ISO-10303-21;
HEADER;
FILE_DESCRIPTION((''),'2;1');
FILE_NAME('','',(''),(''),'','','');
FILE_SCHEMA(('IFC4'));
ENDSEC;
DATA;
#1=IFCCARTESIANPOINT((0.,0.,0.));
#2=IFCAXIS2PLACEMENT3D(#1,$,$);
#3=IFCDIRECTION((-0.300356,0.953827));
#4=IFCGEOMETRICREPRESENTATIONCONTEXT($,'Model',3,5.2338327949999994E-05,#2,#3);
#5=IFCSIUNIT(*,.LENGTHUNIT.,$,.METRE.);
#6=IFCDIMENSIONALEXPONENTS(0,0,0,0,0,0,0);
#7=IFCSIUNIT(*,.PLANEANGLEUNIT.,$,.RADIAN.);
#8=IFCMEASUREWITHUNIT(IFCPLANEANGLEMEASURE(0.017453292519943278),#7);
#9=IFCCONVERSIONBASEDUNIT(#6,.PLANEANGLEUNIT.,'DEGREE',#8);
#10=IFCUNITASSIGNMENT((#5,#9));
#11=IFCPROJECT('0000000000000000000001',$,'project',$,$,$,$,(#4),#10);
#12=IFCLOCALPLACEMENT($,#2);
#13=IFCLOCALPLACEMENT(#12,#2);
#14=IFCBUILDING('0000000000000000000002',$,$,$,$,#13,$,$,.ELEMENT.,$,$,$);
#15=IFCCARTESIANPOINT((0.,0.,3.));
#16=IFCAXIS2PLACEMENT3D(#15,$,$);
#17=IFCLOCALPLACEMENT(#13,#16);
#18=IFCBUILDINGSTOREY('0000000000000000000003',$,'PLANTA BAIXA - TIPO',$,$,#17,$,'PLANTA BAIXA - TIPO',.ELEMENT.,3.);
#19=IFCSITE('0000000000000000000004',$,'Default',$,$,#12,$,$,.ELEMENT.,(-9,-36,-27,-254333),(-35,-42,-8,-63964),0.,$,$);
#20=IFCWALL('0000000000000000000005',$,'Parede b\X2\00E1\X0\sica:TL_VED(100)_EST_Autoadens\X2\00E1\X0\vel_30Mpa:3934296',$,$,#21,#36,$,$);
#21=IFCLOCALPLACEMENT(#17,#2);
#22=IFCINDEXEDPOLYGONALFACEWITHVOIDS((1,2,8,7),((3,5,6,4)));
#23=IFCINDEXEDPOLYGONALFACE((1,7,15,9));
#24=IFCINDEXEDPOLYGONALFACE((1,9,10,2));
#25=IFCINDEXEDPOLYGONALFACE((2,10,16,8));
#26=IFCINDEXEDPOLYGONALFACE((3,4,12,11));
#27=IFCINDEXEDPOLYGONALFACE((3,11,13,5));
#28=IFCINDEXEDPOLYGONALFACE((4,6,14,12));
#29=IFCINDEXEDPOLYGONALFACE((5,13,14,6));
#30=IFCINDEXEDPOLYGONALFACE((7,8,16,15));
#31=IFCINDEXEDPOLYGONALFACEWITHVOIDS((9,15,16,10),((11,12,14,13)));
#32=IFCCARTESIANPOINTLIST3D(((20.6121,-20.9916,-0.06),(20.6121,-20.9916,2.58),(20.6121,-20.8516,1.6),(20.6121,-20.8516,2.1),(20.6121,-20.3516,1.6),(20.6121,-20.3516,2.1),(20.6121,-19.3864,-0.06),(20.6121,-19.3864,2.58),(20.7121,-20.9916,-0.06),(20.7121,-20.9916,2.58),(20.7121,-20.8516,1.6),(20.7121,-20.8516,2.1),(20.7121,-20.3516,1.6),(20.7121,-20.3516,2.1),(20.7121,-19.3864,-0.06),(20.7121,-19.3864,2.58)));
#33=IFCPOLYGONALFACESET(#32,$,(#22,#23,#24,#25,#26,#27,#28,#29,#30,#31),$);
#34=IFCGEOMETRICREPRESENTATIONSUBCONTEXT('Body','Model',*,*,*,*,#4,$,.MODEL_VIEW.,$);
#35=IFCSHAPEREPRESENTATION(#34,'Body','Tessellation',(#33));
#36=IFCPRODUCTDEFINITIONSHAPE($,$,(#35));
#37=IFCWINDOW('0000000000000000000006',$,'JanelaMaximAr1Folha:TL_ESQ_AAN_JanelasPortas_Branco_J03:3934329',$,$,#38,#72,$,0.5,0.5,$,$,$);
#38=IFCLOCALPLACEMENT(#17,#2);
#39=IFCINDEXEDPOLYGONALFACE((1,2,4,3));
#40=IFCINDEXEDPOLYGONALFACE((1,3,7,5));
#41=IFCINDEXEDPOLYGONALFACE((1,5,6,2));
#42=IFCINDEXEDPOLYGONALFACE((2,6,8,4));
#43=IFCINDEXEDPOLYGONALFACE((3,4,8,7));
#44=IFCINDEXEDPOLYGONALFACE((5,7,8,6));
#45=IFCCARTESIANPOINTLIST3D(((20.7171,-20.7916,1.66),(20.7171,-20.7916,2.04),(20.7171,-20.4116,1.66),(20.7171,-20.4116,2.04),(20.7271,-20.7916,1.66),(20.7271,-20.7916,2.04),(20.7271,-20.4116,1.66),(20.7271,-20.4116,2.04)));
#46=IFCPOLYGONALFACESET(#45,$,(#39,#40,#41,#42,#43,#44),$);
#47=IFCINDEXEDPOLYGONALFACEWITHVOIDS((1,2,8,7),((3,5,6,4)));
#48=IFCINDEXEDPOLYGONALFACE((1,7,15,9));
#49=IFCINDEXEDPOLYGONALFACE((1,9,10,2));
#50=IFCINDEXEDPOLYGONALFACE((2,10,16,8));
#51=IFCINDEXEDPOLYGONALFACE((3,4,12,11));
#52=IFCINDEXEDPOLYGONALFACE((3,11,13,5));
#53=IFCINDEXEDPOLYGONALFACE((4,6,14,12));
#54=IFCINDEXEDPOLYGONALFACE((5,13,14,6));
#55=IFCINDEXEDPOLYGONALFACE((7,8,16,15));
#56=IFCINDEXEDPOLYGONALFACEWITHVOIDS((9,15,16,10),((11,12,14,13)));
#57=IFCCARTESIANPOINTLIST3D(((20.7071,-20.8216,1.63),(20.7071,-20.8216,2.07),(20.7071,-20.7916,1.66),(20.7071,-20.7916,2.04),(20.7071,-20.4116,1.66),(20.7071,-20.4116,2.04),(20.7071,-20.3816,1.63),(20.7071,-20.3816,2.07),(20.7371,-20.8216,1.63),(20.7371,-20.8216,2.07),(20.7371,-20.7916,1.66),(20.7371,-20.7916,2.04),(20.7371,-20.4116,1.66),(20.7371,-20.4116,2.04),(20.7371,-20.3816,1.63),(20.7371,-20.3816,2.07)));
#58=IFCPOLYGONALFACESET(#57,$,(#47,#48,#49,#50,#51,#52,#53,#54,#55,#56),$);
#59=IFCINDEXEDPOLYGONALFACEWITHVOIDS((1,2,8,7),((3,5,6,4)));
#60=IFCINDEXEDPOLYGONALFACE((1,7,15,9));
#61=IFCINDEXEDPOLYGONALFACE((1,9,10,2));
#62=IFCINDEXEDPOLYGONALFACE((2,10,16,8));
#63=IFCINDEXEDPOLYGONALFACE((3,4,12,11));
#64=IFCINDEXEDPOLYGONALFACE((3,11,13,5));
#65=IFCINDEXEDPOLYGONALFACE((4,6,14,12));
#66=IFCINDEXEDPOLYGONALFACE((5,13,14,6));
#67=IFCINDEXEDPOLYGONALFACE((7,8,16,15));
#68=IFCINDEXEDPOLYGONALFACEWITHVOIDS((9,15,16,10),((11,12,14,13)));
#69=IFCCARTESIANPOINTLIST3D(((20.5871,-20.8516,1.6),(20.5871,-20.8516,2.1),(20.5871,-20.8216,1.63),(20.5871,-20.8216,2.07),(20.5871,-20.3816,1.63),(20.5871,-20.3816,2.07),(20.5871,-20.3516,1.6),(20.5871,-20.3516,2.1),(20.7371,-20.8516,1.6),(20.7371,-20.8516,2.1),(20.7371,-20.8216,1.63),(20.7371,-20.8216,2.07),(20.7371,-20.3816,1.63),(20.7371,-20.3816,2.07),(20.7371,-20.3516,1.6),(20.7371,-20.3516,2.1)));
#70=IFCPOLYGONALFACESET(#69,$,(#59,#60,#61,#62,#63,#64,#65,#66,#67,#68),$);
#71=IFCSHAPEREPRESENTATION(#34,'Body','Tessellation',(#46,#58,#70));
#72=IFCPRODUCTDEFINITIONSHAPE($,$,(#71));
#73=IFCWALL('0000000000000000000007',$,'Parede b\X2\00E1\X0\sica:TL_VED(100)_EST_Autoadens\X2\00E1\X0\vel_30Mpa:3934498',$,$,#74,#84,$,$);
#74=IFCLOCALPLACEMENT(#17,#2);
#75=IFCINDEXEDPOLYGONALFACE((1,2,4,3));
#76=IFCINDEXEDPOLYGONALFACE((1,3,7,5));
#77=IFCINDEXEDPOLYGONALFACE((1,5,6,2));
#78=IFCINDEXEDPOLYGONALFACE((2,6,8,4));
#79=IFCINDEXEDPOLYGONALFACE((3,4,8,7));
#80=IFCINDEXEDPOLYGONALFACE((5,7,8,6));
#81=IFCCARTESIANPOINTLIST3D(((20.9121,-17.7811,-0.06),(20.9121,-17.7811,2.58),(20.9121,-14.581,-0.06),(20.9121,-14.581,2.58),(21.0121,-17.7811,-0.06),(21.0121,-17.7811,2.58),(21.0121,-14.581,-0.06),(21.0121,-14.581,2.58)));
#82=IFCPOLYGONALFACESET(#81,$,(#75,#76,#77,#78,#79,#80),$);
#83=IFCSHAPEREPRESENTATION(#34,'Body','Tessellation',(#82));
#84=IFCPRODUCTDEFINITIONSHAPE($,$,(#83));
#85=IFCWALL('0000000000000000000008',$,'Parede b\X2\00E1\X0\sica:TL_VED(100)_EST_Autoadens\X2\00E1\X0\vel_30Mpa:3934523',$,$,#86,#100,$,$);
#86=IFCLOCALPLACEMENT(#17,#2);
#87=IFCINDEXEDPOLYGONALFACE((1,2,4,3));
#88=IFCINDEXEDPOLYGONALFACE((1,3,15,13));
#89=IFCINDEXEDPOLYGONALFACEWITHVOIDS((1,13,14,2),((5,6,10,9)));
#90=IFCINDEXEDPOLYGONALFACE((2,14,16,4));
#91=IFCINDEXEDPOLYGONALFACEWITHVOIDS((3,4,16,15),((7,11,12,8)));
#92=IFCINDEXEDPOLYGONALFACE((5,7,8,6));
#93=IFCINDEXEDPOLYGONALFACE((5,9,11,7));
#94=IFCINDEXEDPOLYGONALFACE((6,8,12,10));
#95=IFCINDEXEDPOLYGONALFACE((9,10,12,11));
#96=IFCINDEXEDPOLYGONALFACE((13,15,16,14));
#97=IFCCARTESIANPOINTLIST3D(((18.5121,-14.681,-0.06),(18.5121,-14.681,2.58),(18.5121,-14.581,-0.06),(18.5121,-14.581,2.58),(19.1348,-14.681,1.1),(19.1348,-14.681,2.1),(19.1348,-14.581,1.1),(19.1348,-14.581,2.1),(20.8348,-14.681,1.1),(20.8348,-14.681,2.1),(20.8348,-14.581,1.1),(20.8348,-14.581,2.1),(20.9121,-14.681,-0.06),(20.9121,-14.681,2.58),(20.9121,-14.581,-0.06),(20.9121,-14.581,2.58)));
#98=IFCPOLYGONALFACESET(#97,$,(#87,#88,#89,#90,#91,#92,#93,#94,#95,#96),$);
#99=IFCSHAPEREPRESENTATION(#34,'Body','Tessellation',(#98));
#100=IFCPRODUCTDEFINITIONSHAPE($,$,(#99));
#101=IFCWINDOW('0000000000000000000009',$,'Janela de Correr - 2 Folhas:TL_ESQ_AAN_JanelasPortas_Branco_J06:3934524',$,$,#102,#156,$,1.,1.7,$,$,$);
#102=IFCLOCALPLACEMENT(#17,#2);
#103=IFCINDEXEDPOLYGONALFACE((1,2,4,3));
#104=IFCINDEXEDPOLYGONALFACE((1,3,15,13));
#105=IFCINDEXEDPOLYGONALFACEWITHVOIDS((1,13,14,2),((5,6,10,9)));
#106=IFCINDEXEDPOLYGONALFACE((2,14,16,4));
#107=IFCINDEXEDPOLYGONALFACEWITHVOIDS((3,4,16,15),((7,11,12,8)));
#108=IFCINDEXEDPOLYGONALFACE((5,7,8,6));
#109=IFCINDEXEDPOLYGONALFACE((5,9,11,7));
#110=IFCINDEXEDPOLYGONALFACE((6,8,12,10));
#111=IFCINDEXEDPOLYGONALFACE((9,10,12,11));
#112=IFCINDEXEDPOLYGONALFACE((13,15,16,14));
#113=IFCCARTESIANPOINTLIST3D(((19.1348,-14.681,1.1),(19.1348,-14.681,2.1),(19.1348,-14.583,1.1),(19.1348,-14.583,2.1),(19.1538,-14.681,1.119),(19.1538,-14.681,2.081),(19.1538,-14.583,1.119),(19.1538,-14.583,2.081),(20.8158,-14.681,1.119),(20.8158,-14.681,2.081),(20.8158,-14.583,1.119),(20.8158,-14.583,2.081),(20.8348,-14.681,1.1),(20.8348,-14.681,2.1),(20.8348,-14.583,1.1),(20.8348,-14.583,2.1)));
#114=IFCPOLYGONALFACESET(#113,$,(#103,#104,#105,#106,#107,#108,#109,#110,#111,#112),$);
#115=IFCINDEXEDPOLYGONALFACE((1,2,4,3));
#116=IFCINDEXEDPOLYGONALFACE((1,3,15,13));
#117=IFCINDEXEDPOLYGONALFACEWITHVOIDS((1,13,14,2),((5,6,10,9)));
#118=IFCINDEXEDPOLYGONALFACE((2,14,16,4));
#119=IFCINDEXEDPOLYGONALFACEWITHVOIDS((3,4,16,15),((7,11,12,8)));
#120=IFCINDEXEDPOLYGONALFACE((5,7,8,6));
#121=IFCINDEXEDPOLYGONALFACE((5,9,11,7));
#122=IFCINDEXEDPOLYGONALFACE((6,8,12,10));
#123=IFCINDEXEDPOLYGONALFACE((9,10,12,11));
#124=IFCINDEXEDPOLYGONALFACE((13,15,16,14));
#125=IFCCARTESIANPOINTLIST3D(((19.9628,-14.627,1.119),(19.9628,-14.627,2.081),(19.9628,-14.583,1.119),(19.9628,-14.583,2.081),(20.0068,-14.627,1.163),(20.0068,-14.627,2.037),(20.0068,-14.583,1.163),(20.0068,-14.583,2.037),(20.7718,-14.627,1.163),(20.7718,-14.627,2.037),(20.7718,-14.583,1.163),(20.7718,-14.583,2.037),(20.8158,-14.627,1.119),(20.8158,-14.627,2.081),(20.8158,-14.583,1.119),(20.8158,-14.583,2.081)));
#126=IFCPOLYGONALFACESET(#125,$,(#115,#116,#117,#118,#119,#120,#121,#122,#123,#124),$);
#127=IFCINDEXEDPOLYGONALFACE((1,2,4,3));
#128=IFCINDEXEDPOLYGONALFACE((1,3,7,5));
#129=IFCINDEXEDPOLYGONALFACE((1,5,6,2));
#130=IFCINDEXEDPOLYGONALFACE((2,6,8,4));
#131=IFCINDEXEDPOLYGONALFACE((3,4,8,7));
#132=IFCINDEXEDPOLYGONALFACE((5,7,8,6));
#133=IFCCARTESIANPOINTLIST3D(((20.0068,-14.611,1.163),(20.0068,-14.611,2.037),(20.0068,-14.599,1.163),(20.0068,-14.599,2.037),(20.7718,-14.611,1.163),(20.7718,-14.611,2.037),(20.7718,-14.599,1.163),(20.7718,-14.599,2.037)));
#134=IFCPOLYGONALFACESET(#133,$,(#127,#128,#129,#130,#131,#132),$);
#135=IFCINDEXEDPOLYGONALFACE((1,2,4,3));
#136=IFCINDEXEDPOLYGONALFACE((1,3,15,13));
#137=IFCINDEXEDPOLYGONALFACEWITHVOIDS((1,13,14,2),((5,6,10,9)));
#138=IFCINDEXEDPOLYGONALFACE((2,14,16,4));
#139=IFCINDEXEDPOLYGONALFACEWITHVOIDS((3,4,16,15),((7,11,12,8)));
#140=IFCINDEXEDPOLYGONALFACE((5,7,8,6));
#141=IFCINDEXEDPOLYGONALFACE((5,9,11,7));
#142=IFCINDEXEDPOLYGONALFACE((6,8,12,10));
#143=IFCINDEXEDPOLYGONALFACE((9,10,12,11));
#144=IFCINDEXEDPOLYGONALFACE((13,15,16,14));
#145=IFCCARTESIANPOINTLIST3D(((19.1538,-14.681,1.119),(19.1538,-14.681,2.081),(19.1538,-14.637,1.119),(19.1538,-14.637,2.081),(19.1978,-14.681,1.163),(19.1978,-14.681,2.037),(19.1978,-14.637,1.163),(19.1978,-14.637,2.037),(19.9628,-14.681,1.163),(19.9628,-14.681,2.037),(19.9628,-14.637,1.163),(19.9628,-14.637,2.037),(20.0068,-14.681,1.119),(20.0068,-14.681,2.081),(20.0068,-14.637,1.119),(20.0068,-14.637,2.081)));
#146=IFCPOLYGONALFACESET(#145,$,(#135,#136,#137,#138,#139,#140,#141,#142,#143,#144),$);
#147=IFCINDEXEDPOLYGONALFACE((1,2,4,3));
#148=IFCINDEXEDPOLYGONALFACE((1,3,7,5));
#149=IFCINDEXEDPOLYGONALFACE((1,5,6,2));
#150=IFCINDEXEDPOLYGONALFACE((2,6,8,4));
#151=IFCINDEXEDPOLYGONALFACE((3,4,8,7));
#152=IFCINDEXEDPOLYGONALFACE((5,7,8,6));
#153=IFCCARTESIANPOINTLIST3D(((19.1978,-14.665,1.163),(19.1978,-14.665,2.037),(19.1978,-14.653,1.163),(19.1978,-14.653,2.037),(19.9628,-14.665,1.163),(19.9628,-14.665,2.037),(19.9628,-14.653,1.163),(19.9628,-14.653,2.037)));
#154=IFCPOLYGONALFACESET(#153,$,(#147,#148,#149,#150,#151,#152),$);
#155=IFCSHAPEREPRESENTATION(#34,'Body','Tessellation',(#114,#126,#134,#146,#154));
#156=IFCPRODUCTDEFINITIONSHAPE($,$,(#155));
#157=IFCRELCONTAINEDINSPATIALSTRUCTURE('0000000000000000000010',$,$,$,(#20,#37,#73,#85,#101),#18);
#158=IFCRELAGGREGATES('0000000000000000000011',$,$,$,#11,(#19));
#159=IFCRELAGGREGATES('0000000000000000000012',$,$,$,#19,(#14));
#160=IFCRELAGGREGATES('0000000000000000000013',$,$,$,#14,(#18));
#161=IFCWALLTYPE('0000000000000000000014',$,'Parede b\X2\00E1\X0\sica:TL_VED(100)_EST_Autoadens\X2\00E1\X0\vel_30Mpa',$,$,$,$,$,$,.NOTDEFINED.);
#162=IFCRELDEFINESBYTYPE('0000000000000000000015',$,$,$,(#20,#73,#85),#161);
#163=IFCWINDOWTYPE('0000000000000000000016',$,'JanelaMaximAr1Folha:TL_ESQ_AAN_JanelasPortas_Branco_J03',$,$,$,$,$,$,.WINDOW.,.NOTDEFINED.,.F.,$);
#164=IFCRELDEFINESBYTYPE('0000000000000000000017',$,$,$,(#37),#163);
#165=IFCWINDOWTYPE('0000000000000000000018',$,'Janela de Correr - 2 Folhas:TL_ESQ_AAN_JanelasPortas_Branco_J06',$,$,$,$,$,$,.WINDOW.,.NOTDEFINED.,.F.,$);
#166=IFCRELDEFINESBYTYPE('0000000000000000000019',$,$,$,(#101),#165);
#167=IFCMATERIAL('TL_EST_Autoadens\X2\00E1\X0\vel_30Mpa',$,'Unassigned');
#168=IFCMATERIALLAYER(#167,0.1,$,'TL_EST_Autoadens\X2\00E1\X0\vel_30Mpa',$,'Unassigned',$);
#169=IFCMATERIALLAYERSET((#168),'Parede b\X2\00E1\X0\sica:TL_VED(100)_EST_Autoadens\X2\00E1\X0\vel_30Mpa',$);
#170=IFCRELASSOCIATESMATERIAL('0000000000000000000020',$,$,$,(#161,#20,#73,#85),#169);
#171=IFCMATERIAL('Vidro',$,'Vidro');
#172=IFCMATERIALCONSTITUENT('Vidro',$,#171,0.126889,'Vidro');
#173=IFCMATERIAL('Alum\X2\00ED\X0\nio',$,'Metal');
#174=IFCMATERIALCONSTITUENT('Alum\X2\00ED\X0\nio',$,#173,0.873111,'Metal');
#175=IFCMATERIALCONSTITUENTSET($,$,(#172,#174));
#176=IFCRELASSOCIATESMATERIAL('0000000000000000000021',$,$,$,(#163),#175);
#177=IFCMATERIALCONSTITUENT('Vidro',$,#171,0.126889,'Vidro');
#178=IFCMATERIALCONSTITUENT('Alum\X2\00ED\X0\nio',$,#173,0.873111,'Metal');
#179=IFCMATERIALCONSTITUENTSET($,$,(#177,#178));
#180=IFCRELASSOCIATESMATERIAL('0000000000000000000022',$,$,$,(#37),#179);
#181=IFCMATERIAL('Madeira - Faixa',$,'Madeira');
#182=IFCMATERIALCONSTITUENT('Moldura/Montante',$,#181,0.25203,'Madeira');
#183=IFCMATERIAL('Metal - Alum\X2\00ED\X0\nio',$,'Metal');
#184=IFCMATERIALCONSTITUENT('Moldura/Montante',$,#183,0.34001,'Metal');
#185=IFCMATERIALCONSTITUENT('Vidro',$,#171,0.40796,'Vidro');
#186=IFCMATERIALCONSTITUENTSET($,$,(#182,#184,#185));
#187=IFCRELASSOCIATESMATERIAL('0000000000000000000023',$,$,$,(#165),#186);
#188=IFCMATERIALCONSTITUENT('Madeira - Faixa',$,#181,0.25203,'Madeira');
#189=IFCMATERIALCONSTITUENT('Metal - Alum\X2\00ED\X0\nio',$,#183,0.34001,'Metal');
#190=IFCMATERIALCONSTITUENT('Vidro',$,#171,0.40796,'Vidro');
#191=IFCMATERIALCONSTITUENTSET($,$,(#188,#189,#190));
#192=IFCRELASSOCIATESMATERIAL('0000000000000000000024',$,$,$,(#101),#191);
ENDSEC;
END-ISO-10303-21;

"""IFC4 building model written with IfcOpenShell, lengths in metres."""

from ifc_helpers import new_model, entity, si_unit, converted_unit, direction, frame, frame_2d, origin, origin_2d_with_axis, place, context, subcontext, project, spatial, polyline, rectangle, outline, extrude, source, transform, mapped, material, layer, layer_set, layer_usage, constituent, constituent_set, type_object, type_shapes, element, fill, save


model = new_model("IFC4")

# Units and contexts
model_context = context("Model", 3, precision=5.2338327949999994e-05, world=origin(), true_north=direction((-0.300356, 0.953827)))
body_context = subcontext(model_context, "Body", "Model", "MODEL_VIEW")
ifc_project = project(units=[si_unit("LENGTHUNIT", "METRE"), converted_unit("PLANEANGLEUNIT", "DEGREE", entity("IfcPlaneAngleMeasure", 0.017453292519943278), si_unit("PLANEANGLEUNIT", "RADIAN"), dimensions=[0, 0, 0, 0, 0, 0, 0])], contexts=[model_context])

# Site, building, storey
site_placement = place(None, origin())
site = spatial("IfcSite", under=ifc_project, at=site_placement, Name="Default", CompositionType="ELEMENT", RefLatitude=(-9, -36, -27, -254333), RefLongitude=(-35, -42, -8, -63964), RefElevation=0.0)
building_placement = place(site_placement, origin())
building = spatial("IfcBuilding", under=site, at=building_placement, CompositionType="ELEMENT")
storey_placement = place(building_placement, frame((0.0, 0.0, 3.0)))
storey = spatial("IfcBuildingStorey", under=building, at=storey_placement, Name="PLANTA BAIXA - TIPO", LongName="PLANTA BAIXA - TIPO", CompositionType="ELEMENT", Elevation=3.0)

# Wall, opening, window
ifc_material_1 = material(Name="TL_EST_Autoadensável_30Mpa", Category="Unassigned")
ifc_layer_1 = layer(ifc_material_1, 0.1, Name="TL_EST_Autoadensável_30Mpa", Category="Unassigned")
ifc_layer_set_1 = layer_set([ifc_layer_1], Name="Parede básica:TL_VED(100)_EST_Autoadensável_30Mpa")
ifc_layer_usage_1 = layer_usage(ifc_layer_set_1, "AXIS2", "NEGATIVE", 0.05)
wall_type_1 = type_object("IfcWallType", Name="Parede básica:TL_VED(100)_EST_Autoadensável_30Mpa", PredefinedType="NOTDEFINED", material=ifc_layer_set_1)
wall_1_placement = place(storey_placement, frame((20.6621, -19.3864, -0.06), z_axis=(0.0, 0.0, 1.0), x_axis=(0.0, -1.0, 0.0)))
wall_1 = element("IfcWall", 1, at=wall_1_placement, inside=storey, type_object=wall_type_1, material=ifc_layer_usage_1, Name="Parede básica:TL_VED(100)_EST_Autoadensável_30Mpa:3934296", context=body_context, shape_type="SweptSolid", body=[
    extrude(rectangle(XDim=1.6052, YDim=0.1, at=frame_2d((0.8026, 0.0), x_axis=(-1.0, 0.0))), origin(), (0.0, 0.0, 1.0), 2.64),
])
opening_1_placement = place(wall_1_placement, frame((1.4652, 0.05, 1.66)))
opening_1 = element("IfcOpeningElement", 2, at=opening_1_placement, cuts=wall_1, PredefinedType="OPENING", context=body_context, shape_type="SweptSolid", body=[
    extrude(rectangle(XDim=0.5, YDim=0.5, at=frame_2d((0.25, 0.25), x_axis=(1.0, 0.0))), frame((0.0, 0.0, 0.0), z_axis=(0.0, -1.0, 0.0), x_axis=(0.0, 0.0, 1.0)), (0.0, 0.0, 1.0), 0.1),
])
ifc_material_2 = material(Name="Vidro", Category="Vidro")
ifc_constituent_1 = constituent(ifc_material_2, Name="Vidro", Category="Vidro", fraction=0.126889)
ifc_material_3 = material(Name="Alumínio", Category="Metal")
ifc_constituent_2 = constituent(ifc_material_3, Name="Alumínio", Category="Metal", fraction=0.873111)
ifc_constituent_set_1 = constituent_set(constituents=[ifc_constituent_1, ifc_constituent_2])
ifc_constituent_3 = constituent(ifc_material_2, Name="Vidro", Category="Vidro", fraction=0.126889)
ifc_constituent_4 = constituent(ifc_material_3, Name="Alumínio", Category="Metal", fraction=0.873111)
ifc_constituent_set_2 = constituent_set(constituents=[ifc_constituent_3, ifc_constituent_4])
window_type_1 = type_object("IfcWindowType", Name="JanelaMaximAr1Folha:TL_ESQ_AAN_JanelasPortas_Branco_J03", ParameterTakesPrecedence=False, PartitioningType="NOTDEFINED", PredefinedType="WINDOW", material=ifc_constituent_set_2)
shared_shape_1 = source(origin(), body_context, "Body", "SweptSolid", [
    extrude(rectangle(XDim=0.01, YDim=0.38, at=frame_2d((0.0, 0.0), x_axis=(1.0, 0.0))), frame((0.25, -0.01, 0.06), z_axis=(0.0, 0.0, 1.0), x_axis=(0.0, 1.0, 0.0)), (0.0, 0.0, 1.0), 0.38),
    extrude(outline(polyline([(-0.22, -0.22), (0.22, -0.22), (0.22, 0.22), (-0.22, 0.22), (-0.22, -0.22)]), holes=[polyline([(0.19, 0.19), (0.19, -0.19), (-0.19, -0.19), (-0.19, 0.19), (0.19, 0.19)])]), frame((0.25, -0.025, 0.25), z_axis=(0.0, 1.0, 0.0), x_axis=(0.0, 0.0, -1.0)), (0.0, 0.0, 1.0), 0.03),
    extrude(outline(polyline([(-0.25, -0.25), (0.25, -0.25), (0.25, 0.25), (-0.25, 0.25), (-0.25, -0.25)]), holes=[polyline([(-0.22, -0.22), (-0.22, 0.22), (0.22, 0.22), (0.22, -0.22), (-0.22, -0.22)])]), frame((0.25, -0.025, 0.25), z_axis=(0.0, 1.0, 0.0), x_axis=(0.0, 0.0, -1.0)), (0.0, 0.0, 1.0), 0.15),
])
type_shapes(window_type_1, [shared_shape_1])
window_1_placement = place(opening_1_placement, frame((0.0, 0.0, 0.0), z_axis=(0.0, 0.0, 1.0), x_axis=(-1.0, 0.0, 0.0)))
window_1 = element("IfcWindow", 3, at=window_1_placement, inside=storey, type_object=window_type_1, material=ifc_constituent_set_1, Name="JanelaMaximAr1Folha:TL_ESQ_AAN_JanelasPortas_Branco_J03:3934329", OverallHeight=0.5, OverallWidth=0.5, context=body_context, shape_type="MappedRepresentation", body=[
    mapped(shared_shape_1, transform((0.0, 0.0, 0.0), scale=1.0)),
])
fill(opening_1, window_1)

# Wall
ifc_layer_usage_2 = layer_usage(ifc_layer_set_1, "AXIS2", "POSITIVE", -0.05)
wall_2_placement = place(storey_placement, frame((20.9621, -14.581, -0.06), z_axis=(0.0, 0.0, 1.0), x_axis=(0.0, -1.0, 0.0)))
element("IfcWall", 4, at=wall_2_placement, inside=storey, type_object=wall_type_1, material=ifc_layer_usage_2, Name="Parede básica:TL_VED(100)_EST_Autoadensável_30Mpa:3934498", context=body_context, shape_type="SweptSolid", body=[
    extrude(rectangle(XDim=3.2001, YDim=0.1, at=frame_2d((1.6001, 0.0), x_axis=(-1.0, 0.0))), origin(), (0.0, 0.0, 1.0), 2.64),
])

# Wall, opening, window
ifc_layer_usage_3 = layer_usage(ifc_layer_set_1, "AXIS2", "POSITIVE", -0.05)
wall_3_placement = place(storey_placement, frame((20.9121, -14.631, -0.06), z_axis=(0.0, 0.0, 1.0), x_axis=(-1.0, 0.0, 0.0)))
wall_3 = element("IfcWall", 5, at=wall_3_placement, inside=storey, type_object=wall_type_1, material=ifc_layer_usage_3, Name="Parede básica:TL_VED(100)_EST_Autoadensável_30Mpa:3934523", context=body_context, shape_type="SweptSolid", body=[
    extrude(rectangle(XDim=2.4, YDim=0.1, at=frame_2d((1.2, 0.0), x_axis=(-1.0, 0.0))), origin(), (0.0, 0.0, 1.0), 2.64),
])
opening_2_placement = place(wall_3_placement, frame((1.7774, 0.05, 1.16)))
opening_2 = element("IfcOpeningElement", 6, at=opening_2_placement, cuts=wall_3, PredefinedType="OPENING", context=body_context, shape_type="SweptSolid", body=[
    extrude(rectangle(XDim=1.0, YDim=1.7, at=frame_2d((0.5, 0.85), x_axis=(-1.0, 0.0))), frame((0.0, 0.0, 0.0), z_axis=(0.0, -1.0, 0.0), x_axis=(0.0, 0.0, 1.0)), (0.0, 0.0, 1.0), 0.1),
])
ifc_material_4 = material(Name="Madeira - Faixa", Category="Madeira")
ifc_constituent_5 = constituent(ifc_material_4, Name="Madeira - Faixa", Category="Madeira", fraction=0.25203)
ifc_material_5 = material(Name="Metal - Alumínio", Category="Metal")
ifc_constituent_6 = constituent(ifc_material_5, Name="Metal - Alumínio", Category="Metal", fraction=0.34001)
ifc_constituent_7 = constituent(ifc_material_2, Name="Vidro", Category="Vidro", fraction=0.40796)
ifc_constituent_set_3 = constituent_set(constituents=[ifc_constituent_5, ifc_constituent_6, ifc_constituent_7])
ifc_constituent_8 = constituent(ifc_material_4, Name="Moldura/Montante", Category="Madeira", fraction=0.25203)
ifc_constituent_9 = constituent(ifc_material_5, Name="Moldura/Montante", Category="Metal", fraction=0.34001)
ifc_constituent_10 = constituent(ifc_material_2, Name="Vidro", Category="Vidro", fraction=0.40796)
ifc_constituent_set_4 = constituent_set(constituents=[ifc_constituent_8, ifc_constituent_9, ifc_constituent_10])
window_type_2 = type_object("IfcWindowType", Name="Janela de Correr - 2 Folhas:TL_ESQ_AAN_JanelasPortas_Branco_J06", ParameterTakesPrecedence=False, PartitioningType="NOTDEFINED", PredefinedType="WINDOW", material=ifc_constituent_set_4)
shared_shape_2 = source(origin(), body_context, "Body", "SweptSolid", [
    extrude(outline(polyline([(-0.85, -0.5), (0.85, -0.5), (0.85, 0.5), (-0.85, 0.5), (-0.85, -0.5)]), holes=[polyline([(-0.831, -0.481), (-0.831, 0.481), (0.831, 0.481), (0.831, -0.481), (-0.831, -0.481)])]), frame((0.85, 0.0, 0.5), z_axis=(0.0, 1.0, 0.0), x_axis=(1.0, 0.0, 0.0)), (0.0, 0.0, 1.0), 0.098),
    extrude(outline(polyline([(-0.4265, -0.481), (0.4265, -0.481), (0.4265, 0.481), (-0.4265, 0.481), (-0.4265, -0.481)]), holes=[polyline([(-0.3825, -0.437), (-0.3825, 0.437), (0.3825, 0.437), (0.3825, -0.437), (-0.3825, -0.437)])]), frame((1.2545, 0.054, 0.5), z_axis=(0.0, 1.0, 0.0), x_axis=(1.0, 0.0, 0.0)), (0.0, 0.0, 1.0), 0.044),
    extrude(rectangle(XDim=0.012, YDim=0.765, at=origin_2d_with_axis()), frame((1.2545, 0.076, 0.063), z_axis=(0.0, 0.0, 1.0), x_axis=(0.0, -1.0, 0.0)), (0.0, 0.0, 1.0), 0.874),
    extrude(outline(polyline([(-0.481, -0.4265), (0.481, -0.4265), (0.481, 0.4265), (-0.481, 0.4265), (-0.481, -0.4265)]), holes=[polyline([(-0.437, -0.3825), (-0.437, 0.3825), (0.437, 0.3825), (0.437, -0.3825), (-0.437, -0.3825)])]), frame((0.4455, 0.0, 0.5), z_axis=(0.0, 1.0, 0.0), x_axis=(0.0, 0.0, -1.0)), (0.0, 0.0, 1.0), 0.044),
    extrude(rectangle(XDim=0.012, YDim=0.765, at=origin_2d_with_axis()), frame((0.4455, 0.022, 0.063), z_axis=(0.0, 0.0, 1.0), x_axis=(0.0, -1.0, 0.0)), (0.0, 0.0, 1.0), 0.874),
])
type_shapes(window_type_2, [shared_shape_2])
window_2_placement = place(opening_2_placement, frame((0.0, 0.0, 0.0), z_axis=(0.0, 0.0, 1.0), x_axis=(-1.0, 0.0, 0.0)))
window_2 = element("IfcWindow", 7, at=window_2_placement, inside=storey, type_object=window_type_2, material=ifc_constituent_set_3, Name="Janela de Correr - 2 Folhas:TL_ESQ_AAN_JanelasPortas_Branco_J06:3934524", OverallHeight=1.0, OverallWidth=1.7, context=body_context, shape_type="MappedRepresentation", body=[
    mapped(shared_shape_2, transform((0.0, 0.0, 0.0), scale=1.0)),
])
fill(opening_2, window_2)

save(model, "model.ifc")
